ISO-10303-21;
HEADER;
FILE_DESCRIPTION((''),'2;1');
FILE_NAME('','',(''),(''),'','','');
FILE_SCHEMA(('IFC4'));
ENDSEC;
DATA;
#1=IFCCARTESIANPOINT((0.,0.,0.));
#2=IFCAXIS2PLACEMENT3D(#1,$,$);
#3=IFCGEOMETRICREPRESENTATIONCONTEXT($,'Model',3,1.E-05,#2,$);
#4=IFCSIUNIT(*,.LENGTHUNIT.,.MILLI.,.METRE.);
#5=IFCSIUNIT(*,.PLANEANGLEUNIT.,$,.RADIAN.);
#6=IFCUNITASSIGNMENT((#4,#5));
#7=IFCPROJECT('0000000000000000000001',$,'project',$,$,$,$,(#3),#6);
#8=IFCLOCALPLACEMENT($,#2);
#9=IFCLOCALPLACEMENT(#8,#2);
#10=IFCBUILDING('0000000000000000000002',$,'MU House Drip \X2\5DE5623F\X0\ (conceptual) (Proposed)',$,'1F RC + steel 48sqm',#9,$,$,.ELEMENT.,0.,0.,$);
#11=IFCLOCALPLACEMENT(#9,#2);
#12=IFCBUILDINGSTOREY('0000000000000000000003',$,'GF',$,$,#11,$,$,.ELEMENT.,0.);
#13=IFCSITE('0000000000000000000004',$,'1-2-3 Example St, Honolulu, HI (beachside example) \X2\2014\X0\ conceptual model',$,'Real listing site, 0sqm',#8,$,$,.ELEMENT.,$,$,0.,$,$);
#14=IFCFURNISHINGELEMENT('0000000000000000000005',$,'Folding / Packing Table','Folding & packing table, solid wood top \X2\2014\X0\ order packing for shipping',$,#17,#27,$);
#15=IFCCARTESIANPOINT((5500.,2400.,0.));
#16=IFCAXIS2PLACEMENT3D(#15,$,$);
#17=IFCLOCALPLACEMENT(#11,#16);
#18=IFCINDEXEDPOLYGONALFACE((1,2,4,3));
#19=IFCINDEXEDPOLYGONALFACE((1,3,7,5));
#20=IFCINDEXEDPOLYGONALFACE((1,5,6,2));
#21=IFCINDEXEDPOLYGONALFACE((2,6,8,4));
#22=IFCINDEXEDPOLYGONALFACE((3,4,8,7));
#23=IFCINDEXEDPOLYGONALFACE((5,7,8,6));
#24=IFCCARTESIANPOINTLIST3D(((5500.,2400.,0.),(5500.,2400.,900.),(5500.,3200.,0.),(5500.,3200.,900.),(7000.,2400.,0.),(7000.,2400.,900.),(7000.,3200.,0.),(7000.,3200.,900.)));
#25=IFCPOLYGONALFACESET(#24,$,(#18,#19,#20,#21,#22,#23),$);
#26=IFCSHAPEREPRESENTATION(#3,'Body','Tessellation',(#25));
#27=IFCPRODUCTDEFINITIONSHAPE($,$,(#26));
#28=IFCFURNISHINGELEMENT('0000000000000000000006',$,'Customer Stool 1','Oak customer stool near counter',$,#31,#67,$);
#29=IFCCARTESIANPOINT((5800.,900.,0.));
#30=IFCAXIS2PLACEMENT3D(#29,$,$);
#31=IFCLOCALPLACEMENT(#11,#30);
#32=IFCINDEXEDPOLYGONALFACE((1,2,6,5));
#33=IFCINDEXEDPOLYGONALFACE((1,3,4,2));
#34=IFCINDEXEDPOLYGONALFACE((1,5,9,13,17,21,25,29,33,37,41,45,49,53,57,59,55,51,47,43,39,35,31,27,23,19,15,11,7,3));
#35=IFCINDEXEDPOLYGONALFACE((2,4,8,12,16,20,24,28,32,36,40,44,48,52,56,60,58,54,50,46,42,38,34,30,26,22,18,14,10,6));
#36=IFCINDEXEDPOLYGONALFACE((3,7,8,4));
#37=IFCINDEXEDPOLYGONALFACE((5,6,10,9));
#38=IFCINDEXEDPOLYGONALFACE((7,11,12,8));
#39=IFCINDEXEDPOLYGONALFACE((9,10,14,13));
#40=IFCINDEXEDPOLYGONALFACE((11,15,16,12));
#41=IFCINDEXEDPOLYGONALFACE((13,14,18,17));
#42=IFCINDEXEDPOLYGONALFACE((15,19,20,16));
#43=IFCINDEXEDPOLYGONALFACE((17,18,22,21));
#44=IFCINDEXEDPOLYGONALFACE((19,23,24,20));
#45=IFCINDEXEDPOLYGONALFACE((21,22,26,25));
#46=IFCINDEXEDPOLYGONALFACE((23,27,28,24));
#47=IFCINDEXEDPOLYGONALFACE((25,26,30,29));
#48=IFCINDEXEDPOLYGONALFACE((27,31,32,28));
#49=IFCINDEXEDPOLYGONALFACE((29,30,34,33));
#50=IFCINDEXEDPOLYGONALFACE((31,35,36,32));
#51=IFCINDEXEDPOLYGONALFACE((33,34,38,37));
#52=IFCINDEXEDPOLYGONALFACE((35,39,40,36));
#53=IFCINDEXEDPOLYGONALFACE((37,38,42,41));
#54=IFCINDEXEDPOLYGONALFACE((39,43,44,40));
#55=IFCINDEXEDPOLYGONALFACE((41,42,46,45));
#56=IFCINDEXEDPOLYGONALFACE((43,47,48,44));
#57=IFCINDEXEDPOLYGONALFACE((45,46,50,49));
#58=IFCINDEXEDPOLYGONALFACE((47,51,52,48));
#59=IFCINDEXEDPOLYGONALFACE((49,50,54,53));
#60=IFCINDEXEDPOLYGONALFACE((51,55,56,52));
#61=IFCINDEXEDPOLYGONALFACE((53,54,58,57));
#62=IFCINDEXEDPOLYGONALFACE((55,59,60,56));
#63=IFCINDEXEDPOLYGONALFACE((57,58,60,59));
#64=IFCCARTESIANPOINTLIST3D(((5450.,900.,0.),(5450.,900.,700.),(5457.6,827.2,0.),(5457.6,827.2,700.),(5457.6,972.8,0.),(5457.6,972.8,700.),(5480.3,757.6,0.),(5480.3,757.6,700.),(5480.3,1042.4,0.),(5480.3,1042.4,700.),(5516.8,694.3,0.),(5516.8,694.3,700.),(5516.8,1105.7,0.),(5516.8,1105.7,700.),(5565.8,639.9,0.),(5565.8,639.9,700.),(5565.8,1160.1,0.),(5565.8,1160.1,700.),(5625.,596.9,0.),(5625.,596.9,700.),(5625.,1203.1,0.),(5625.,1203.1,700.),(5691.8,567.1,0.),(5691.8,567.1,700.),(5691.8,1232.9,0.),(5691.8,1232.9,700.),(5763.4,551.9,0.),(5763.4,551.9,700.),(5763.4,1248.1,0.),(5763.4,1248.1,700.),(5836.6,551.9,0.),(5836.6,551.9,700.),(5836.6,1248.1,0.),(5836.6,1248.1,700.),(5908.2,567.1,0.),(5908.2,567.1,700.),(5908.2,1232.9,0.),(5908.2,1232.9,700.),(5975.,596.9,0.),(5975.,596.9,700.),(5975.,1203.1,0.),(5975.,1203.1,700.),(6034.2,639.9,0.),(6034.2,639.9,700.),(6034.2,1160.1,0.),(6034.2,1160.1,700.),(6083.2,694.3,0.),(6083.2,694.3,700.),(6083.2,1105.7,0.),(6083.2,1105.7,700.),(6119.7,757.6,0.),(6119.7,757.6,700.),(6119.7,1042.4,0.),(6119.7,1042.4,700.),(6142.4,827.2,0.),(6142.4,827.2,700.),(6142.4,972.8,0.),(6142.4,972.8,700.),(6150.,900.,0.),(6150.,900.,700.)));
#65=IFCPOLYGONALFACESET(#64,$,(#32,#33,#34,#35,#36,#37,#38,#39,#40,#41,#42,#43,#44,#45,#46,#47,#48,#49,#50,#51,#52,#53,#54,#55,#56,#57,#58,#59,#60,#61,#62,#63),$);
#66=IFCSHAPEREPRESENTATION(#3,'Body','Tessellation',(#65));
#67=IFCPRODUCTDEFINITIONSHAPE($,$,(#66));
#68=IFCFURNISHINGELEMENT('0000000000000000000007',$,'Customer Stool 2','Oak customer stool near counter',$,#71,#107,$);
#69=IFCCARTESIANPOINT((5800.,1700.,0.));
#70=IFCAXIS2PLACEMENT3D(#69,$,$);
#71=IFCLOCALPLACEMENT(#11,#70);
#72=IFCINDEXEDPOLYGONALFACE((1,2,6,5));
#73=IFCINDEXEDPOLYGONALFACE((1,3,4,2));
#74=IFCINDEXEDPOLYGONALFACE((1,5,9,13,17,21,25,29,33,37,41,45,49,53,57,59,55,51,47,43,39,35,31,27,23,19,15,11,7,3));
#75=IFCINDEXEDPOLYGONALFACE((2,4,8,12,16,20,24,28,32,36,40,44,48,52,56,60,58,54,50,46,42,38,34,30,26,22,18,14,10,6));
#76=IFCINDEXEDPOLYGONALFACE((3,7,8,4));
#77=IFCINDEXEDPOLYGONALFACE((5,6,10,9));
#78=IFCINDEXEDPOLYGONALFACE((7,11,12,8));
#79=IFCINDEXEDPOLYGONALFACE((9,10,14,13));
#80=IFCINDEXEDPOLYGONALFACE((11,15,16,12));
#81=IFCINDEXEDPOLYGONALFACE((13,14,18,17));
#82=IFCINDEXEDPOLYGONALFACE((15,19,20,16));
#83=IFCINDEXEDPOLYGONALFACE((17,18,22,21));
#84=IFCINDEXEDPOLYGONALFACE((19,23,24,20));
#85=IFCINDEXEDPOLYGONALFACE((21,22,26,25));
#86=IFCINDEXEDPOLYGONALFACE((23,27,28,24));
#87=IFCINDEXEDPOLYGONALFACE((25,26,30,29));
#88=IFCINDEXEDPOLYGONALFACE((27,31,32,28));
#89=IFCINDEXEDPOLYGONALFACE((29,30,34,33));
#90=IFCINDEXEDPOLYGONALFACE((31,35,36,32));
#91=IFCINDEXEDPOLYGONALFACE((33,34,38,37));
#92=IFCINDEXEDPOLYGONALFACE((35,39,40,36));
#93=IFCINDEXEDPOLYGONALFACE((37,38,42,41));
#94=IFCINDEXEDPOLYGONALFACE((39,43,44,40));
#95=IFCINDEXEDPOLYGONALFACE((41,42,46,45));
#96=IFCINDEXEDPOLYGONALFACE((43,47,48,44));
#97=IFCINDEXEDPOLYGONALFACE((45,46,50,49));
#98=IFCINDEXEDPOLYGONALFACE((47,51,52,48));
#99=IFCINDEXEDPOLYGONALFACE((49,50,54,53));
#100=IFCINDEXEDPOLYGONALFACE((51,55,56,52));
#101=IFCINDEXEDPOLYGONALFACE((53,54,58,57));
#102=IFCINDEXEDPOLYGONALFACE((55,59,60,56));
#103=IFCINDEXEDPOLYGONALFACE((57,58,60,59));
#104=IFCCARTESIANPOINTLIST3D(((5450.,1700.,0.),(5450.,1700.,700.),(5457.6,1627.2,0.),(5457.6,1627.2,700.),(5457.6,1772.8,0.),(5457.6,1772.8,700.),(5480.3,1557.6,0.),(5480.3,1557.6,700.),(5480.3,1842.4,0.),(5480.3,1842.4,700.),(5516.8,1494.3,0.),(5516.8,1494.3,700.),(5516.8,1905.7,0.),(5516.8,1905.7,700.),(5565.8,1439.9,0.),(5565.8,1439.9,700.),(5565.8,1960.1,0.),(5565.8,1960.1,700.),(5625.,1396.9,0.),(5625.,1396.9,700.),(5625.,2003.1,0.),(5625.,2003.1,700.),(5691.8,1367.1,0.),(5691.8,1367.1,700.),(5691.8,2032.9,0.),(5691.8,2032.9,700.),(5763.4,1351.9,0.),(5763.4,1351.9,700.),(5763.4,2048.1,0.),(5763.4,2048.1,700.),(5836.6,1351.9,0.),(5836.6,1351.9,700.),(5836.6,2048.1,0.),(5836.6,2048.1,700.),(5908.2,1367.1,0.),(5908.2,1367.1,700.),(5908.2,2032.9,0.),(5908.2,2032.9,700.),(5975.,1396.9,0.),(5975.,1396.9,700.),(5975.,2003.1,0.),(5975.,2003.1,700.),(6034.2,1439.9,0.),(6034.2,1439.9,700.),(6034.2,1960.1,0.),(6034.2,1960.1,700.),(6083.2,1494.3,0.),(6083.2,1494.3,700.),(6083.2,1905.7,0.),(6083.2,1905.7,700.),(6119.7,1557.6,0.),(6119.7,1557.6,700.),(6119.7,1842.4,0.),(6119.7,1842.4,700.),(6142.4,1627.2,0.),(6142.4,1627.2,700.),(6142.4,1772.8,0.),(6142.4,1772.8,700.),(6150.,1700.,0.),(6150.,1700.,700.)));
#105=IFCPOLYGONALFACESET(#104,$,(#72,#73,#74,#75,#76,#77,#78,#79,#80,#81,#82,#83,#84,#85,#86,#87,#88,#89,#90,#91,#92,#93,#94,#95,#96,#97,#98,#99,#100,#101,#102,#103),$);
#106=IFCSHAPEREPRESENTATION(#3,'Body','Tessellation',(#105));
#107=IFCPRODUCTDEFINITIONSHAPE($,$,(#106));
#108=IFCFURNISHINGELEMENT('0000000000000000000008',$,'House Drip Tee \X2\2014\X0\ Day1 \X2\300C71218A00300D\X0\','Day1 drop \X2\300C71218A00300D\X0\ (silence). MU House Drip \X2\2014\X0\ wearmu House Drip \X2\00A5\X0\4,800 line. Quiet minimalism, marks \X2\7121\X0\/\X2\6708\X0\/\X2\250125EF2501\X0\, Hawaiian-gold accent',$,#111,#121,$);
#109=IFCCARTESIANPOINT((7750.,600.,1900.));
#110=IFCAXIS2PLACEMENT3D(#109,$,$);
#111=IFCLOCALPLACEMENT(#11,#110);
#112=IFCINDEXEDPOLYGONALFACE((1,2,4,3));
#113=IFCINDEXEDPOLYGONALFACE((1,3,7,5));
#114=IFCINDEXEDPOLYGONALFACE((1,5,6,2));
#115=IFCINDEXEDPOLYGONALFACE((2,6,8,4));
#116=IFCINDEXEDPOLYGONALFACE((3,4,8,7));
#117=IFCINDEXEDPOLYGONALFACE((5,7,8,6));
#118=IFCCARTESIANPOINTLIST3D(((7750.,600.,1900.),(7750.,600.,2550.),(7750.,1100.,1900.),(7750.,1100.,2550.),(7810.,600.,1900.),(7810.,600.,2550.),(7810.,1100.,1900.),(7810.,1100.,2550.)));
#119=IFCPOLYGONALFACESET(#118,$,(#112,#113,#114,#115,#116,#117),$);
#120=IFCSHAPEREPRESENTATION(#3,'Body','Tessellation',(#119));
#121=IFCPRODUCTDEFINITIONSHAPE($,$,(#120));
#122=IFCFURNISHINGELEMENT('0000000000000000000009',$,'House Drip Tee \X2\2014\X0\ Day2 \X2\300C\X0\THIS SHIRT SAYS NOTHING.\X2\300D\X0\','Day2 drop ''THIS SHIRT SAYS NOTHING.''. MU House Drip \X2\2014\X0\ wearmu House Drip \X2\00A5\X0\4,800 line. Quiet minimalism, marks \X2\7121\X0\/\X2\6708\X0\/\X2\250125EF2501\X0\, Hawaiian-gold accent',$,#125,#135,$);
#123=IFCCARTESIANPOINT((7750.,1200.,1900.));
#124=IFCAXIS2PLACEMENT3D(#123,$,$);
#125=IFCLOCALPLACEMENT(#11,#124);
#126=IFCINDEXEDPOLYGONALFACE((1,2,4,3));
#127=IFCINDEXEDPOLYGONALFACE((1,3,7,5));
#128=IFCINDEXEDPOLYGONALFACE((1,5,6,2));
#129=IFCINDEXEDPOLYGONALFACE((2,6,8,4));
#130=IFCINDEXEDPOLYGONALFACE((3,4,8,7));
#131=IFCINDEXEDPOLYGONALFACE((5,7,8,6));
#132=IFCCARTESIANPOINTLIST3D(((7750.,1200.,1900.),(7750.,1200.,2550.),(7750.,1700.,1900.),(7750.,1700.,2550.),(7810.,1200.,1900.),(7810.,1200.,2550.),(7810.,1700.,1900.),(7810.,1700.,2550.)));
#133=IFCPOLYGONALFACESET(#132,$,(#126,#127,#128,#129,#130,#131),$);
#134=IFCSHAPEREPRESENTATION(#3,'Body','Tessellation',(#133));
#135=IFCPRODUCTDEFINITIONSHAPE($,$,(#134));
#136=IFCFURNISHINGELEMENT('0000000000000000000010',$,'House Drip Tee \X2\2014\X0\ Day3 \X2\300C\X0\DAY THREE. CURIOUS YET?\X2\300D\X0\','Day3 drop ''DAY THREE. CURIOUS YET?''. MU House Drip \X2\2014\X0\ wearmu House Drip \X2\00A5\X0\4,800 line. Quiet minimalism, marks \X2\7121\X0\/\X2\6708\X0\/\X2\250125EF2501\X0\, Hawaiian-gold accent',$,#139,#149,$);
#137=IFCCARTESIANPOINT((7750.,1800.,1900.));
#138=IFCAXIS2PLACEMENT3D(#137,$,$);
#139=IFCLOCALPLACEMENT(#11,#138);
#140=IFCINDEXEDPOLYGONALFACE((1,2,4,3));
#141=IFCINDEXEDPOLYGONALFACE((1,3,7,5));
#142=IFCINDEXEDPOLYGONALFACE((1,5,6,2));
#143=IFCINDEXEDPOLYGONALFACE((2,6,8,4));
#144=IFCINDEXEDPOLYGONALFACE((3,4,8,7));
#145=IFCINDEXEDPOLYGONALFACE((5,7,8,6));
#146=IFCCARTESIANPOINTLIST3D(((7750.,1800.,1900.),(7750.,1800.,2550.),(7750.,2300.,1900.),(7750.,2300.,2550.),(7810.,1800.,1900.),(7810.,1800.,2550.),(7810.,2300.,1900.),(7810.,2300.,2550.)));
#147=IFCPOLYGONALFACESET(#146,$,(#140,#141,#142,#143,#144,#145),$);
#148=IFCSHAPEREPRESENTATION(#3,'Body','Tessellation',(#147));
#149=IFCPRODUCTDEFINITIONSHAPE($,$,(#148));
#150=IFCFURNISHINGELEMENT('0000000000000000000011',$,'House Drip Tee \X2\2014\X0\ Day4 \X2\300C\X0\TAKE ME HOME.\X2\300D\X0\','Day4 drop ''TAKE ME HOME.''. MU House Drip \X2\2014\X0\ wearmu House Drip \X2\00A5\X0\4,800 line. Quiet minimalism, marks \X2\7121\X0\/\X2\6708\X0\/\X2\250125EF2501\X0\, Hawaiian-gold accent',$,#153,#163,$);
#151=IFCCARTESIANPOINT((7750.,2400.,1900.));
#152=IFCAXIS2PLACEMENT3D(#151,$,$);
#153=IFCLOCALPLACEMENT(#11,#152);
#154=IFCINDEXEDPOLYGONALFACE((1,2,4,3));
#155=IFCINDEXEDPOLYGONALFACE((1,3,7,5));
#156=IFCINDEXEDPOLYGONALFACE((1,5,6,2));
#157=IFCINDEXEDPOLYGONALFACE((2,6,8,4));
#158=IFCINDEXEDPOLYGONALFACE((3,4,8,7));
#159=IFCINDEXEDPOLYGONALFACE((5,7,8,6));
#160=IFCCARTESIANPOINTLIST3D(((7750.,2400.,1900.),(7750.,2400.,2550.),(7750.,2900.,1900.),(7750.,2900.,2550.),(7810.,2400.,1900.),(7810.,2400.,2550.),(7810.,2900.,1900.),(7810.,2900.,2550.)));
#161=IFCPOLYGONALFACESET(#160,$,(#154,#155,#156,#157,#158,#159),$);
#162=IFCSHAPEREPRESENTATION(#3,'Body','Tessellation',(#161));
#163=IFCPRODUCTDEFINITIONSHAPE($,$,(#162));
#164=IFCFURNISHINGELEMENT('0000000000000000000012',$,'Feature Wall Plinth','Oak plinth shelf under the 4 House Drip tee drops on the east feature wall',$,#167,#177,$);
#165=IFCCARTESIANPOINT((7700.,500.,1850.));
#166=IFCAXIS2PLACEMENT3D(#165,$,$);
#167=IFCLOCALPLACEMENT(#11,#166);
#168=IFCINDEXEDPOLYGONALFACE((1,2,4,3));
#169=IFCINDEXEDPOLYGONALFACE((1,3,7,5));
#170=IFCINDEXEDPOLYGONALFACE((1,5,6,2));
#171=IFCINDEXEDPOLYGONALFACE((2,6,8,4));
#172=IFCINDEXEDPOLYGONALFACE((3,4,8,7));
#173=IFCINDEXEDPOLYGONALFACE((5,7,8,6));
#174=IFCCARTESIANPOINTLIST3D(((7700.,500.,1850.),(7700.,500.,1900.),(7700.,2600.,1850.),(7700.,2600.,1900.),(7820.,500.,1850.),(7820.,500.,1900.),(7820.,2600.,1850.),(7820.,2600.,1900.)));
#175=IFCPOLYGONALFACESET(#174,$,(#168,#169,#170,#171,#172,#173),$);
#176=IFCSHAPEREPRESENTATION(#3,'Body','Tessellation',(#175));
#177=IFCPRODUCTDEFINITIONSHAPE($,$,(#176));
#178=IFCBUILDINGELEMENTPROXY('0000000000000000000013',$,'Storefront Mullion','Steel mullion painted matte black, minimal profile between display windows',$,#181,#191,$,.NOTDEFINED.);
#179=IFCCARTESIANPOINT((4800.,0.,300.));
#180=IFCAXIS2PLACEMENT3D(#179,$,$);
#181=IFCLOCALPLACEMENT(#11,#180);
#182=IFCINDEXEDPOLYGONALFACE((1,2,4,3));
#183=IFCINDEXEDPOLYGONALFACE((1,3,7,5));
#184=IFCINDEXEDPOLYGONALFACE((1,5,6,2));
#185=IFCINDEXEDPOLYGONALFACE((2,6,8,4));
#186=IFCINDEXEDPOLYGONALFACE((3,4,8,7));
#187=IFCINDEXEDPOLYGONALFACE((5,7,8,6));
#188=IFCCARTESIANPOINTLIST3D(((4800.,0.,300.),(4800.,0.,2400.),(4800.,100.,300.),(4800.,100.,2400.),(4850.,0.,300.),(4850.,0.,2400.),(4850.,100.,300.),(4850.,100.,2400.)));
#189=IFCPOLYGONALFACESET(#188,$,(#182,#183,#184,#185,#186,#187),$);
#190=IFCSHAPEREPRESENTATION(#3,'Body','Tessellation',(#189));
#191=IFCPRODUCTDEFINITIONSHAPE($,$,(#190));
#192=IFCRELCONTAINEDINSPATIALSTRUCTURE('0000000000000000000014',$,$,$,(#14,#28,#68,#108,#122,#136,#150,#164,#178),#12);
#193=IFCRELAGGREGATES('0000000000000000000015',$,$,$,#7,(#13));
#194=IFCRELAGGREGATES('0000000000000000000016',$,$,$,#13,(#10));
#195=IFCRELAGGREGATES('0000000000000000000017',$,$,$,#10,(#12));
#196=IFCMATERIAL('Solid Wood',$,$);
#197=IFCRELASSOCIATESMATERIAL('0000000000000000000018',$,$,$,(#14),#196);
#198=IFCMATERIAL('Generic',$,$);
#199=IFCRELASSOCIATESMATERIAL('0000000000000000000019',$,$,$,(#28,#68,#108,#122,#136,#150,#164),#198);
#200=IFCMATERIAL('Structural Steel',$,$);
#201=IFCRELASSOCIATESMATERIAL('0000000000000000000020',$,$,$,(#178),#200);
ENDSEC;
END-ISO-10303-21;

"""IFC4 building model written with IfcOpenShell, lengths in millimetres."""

from ifc_helpers import new_model, si_unit, frame, frame_2d, origin, origin_2d, place, context, project, spatial, rectangle, circle, extrude, material, element, save


model = new_model("IFC4")

# Units and contexts
model_context = context("Model", 3, precision=1e-05, world=origin())
ifc_project = project(units=[si_unit("LENGTHUNIT", "METRE", prefix="MILLI"), si_unit("PLANEANGLEUNIT", "RADIAN")], contexts=[model_context])

# Site, building, storey
site_placement = place(None, origin())
site = spatial("IfcSite", under=ifc_project, at=site_placement, Name="1-2-3 Example St, Honolulu, HI (beachside example) — conceptual model", ObjectType="Real listing site, 0sqm", CompositionType="ELEMENT", RefElevation=0.0)
building_placement = place(site_placement, origin())
building = spatial("IfcBuilding", under=site, at=building_placement, Name="MU House Drip 工房 (conceptual) (Proposed)", ObjectType="1F RC + steel 48sqm", CompositionType="ELEMENT", ElevationOfRefHeight=0.0, ElevationOfTerrain=0.0)
storey_placement = place(building_placement, origin())
storey = spatial("IfcBuildingStorey", under=building, at=storey_placement, Name="GF", CompositionType="ELEMENT", Elevation=0.0)

# Shared definitions
ifc_material_1 = material(Name="Generic")

# Furnishing elements
ifc_material_2 = material(Name="Structural Steel")
ifc_material_3 = material(Name="Solid Wood")
furnishing_1_placement = place(storey_placement, frame((5500.0, 2400.0, 0.0)))
element("IfcFurnishingElement", 1, at=furnishing_1_placement, inside=storey, material=ifc_material_3, Name="Folding / Packing Table", Description="Folding & packing table, solid wood top — order packing for shipping", context=model_context, shape_type="SweptSolid", body=[
    extrude(rectangle(XDim=1500.0, YDim=800.0, at=frame_2d((750.0, 400.0))), frame((5500.0, 2400.0, 0.0)), (0.0, 0.0, 1.0), 900.0),
])
furnishing_2_placement = place(storey_placement, frame((5800.0, 900.0, 0.0)))
element("IfcFurnishingElement", 2, at=furnishing_2_placement, inside=storey, material=ifc_material_1, Name="Customer Stool 1", Description="Oak customer stool near counter", context=model_context, shape_type="SweptSolid", body=[
    extrude(circle(Radius=350.0, at=origin_2d()), frame((5800.0, 900.0, 0.0)), (0.0, 0.0, 1.0), 700.0),
])
furnishing_3_placement = place(storey_placement, frame((5800.0, 1700.0, 0.0)))
element("IfcFurnishingElement", 3, at=furnishing_3_placement, inside=storey, material=ifc_material_1, Name="Customer Stool 2", Description="Oak customer stool near counter", context=model_context, shape_type="SweptSolid", body=[
    extrude(circle(Radius=350.0, at=origin_2d()), frame((5800.0, 1700.0, 0.0)), (0.0, 0.0, 1.0), 700.0),
])
furnishing_4_placement = place(storey_placement, frame((7750.0, 600.0, 1900.0)))
element("IfcFurnishingElement", 4, at=furnishing_4_placement, inside=storey, material=ifc_material_1, Name="House Drip Tee — Day1 「無言」", Description="Day1 drop 「無言」 (silence). MU House Drip — wearmu House Drip ¥4,800 line. Quiet minimalism, marks 無/月/━◯━, Hawaiian-gold accent", context=model_context, shape_type="SweptSolid", body=[
    extrude(rectangle(XDim=60.0, YDim=500.0, at=frame_2d((30.0, 250.0))), frame((7750.0, 600.0, 1900.0)), (0.0, 0.0, 1.0), 650.0),
])
furnishing_5_placement = place(storey_placement, frame((7750.0, 1200.0, 1900.0)))
element("IfcFurnishingElement", 5, at=furnishing_5_placement, inside=storey, material=ifc_material_1, Name="House Drip Tee — Day2 「THIS SHIRT SAYS NOTHING.」", Description="Day2 drop 'THIS SHIRT SAYS NOTHING.'. MU House Drip — wearmu House Drip ¥4,800 line. Quiet minimalism, marks 無/月/━◯━, Hawaiian-gold accent", context=model_context, shape_type="SweptSolid", body=[
    extrude(rectangle(XDim=60.0, YDim=500.0, at=frame_2d((30.0, 250.0))), frame((7750.0, 1200.0, 1900.0)), (0.0, 0.0, 1.0), 650.0),
])
furnishing_6_placement = place(storey_placement, frame((7750.0, 1800.0, 1900.0)))
element("IfcFurnishingElement", 6, at=furnishing_6_placement, inside=storey, material=ifc_material_1, Name="House Drip Tee — Day3 「DAY THREE. CURIOUS YET?」", Description="Day3 drop 'DAY THREE. CURIOUS YET?'. MU House Drip — wearmu House Drip ¥4,800 line. Quiet minimalism, marks 無/月/━◯━, Hawaiian-gold accent", context=model_context, shape_type="SweptSolid", body=[
    extrude(rectangle(XDim=60.0, YDim=500.0, at=frame_2d((30.0, 250.0))), frame((7750.0, 1800.0, 1900.0)), (0.0, 0.0, 1.0), 650.0),
])
furnishing_7_placement = place(storey_placement, frame((7750.0, 2400.0, 1900.0)))
element("IfcFurnishingElement", 7, at=furnishing_7_placement, inside=storey, material=ifc_material_1, Name="House Drip Tee — Day4 「TAKE ME HOME.」", Description="Day4 drop 'TAKE ME HOME.'. MU House Drip — wearmu House Drip ¥4,800 line. Quiet minimalism, marks 無/月/━◯━, Hawaiian-gold accent", context=model_context, shape_type="SweptSolid", body=[
    extrude(rectangle(XDim=60.0, YDim=500.0, at=frame_2d((30.0, 250.0))), frame((7750.0, 2400.0, 1900.0)), (0.0, 0.0, 1.0), 650.0),
])
furnishing_8_placement = place(storey_placement, frame((7700.0, 500.0, 1850.0)))
element("IfcFurnishingElement", 8, at=furnishing_8_placement, inside=storey, material=ifc_material_1, Name="Feature Wall Plinth", Description="Oak plinth shelf under the 4 House Drip tee drops on the east feature wall", context=model_context, shape_type="SweptSolid", body=[
    extrude(rectangle(XDim=120.0, YDim=2100.0, at=frame_2d((60.0, 1050.0))), frame((7700.0, 500.0, 1850.0)), (0.0, 0.0, 1.0), 50.0),
])

# Building element proxy
proxy_placement = place(storey_placement, frame((4800.0, 0.0, 300.0)))
element("IfcBuildingElementProxy", 9, at=proxy_placement, inside=storey, material=ifc_material_2, Name="Storefront Mullion", Description="Steel mullion painted matte black, minimal profile between display windows", PredefinedType="NOTDEFINED", context=model_context, shape_type="SweptSolid", body=[
    extrude(rectangle(XDim=50.0, YDim=100.0, at=frame_2d((25.0, 50.0))), frame((4800.0, 0.0, 300.0)), (0.0, 0.0, 1.0), 2100.0),
])

save(model, "model.ifc")
